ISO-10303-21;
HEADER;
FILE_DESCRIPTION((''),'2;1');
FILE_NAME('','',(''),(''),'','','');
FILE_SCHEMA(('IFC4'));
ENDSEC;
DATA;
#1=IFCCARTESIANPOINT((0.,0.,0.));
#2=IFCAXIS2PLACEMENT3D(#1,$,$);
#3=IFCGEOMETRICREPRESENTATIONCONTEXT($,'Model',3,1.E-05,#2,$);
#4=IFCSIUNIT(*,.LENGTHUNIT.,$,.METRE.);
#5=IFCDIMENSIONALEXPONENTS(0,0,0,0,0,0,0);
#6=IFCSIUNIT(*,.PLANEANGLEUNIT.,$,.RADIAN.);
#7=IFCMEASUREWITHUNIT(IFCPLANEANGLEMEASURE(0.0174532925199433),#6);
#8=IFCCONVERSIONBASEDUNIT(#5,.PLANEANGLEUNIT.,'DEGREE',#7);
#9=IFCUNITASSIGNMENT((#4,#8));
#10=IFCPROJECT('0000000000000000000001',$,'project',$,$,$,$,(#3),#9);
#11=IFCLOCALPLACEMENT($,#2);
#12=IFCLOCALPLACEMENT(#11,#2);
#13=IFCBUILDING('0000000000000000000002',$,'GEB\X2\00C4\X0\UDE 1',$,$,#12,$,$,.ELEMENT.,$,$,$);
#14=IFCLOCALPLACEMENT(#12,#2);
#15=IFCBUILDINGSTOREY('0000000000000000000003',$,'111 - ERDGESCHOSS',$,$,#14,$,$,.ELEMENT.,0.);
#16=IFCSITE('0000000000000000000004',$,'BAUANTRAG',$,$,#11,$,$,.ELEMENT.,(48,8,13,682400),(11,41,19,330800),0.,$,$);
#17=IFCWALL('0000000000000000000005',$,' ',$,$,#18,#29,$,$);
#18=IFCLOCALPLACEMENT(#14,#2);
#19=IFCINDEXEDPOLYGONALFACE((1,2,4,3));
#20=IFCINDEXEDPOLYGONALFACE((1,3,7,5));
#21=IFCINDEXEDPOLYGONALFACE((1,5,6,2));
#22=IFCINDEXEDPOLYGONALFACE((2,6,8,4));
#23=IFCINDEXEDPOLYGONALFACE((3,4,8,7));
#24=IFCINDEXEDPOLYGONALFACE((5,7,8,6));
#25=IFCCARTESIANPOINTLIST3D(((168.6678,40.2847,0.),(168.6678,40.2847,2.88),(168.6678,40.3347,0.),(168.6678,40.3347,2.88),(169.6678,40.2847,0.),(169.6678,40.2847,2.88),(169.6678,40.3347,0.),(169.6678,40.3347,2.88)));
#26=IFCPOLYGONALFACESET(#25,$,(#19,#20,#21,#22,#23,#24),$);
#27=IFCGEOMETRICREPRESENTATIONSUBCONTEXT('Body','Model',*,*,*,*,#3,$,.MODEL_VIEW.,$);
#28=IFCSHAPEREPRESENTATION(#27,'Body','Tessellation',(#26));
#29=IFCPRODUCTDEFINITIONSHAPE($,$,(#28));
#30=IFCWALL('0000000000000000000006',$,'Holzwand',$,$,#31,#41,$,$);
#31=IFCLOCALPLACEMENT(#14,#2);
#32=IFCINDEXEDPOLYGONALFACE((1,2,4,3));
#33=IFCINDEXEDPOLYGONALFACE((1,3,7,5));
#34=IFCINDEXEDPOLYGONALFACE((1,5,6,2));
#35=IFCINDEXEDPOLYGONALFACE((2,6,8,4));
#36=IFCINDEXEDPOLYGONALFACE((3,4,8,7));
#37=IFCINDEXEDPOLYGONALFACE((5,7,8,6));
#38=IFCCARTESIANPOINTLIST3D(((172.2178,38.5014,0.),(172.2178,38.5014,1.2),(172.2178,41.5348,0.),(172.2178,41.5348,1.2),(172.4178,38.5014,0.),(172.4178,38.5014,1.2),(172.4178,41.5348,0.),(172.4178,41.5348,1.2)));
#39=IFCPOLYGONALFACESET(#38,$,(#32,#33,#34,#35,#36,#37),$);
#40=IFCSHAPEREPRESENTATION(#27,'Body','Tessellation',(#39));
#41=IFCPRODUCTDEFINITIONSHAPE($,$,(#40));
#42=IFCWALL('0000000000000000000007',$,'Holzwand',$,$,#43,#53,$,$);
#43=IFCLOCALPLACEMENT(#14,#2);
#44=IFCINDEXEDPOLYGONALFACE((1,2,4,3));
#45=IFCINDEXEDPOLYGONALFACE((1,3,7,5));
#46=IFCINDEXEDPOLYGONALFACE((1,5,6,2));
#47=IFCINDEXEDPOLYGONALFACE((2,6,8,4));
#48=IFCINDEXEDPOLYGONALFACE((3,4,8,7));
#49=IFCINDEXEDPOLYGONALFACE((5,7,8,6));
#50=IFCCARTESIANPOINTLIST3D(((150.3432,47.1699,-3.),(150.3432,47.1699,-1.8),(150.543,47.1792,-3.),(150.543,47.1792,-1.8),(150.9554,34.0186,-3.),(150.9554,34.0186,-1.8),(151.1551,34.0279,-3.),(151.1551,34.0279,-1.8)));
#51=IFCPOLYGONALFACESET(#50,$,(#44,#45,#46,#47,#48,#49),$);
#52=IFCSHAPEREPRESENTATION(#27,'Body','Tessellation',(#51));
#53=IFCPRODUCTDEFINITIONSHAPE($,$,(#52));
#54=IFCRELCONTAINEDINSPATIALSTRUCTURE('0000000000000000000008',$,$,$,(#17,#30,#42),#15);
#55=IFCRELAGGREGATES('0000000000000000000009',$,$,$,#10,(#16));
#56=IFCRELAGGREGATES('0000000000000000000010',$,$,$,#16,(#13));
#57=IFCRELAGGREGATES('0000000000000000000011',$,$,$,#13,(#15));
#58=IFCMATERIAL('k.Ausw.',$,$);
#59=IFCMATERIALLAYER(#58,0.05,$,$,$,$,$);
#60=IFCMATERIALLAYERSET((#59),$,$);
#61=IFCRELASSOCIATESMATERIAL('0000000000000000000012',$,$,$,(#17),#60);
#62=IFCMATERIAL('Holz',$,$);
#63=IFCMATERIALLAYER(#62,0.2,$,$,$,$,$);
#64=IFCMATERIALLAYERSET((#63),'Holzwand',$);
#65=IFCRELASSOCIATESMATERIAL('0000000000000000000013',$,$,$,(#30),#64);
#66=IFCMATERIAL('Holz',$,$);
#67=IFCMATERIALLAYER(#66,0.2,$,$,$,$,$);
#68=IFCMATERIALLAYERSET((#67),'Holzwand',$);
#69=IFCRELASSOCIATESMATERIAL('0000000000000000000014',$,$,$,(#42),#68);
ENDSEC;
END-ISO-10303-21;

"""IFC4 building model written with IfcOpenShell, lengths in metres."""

from ifc_helpers import new_model, entity, si_unit, converted_unit, frame, frame_2d, origin, origin_with_axes, place, context, subcontext, project, spatial, rectangle, extrude, material, layer, layer_set, layer_usage, element, save


model = new_model("IFC4")

# Units and contexts
model_context = context("Model", 3, precision=1e-05, world=origin())
body_context = subcontext(model_context, "Body", "Model", "MODEL_VIEW")
ifc_project = project(units=[si_unit("LENGTHUNIT", "METRE"), converted_unit("PLANEANGLEUNIT", "DEGREE", entity("IfcPlaneAngleMeasure", 0.0174532925199433), si_unit("PLANEANGLEUNIT", "RADIAN"), dimensions=[0, 0, 0, 0, 0, 0, 0])], contexts=[model_context])

# Site, building, storey
site_placement = place(None, origin())
site = spatial("IfcSite", under=ifc_project, at=site_placement, Name="BAUANTRAG", CompositionType="ELEMENT", RefLatitude=(48, 8, 13, 682400), RefLongitude=(11, 41, 19, 330800), RefElevation=0.0)
building_placement = place(site_placement, origin())
building = spatial("IfcBuilding", under=site, at=building_placement, Name="GEBÄUDE 1", CompositionType="ELEMENT")
storey_placement = place(building_placement, origin())
storey = spatial("IfcBuildingStorey", under=building, at=storey_placement, Name="111 - ERDGESCHOSS", CompositionType="ELEMENT", Elevation=0.0)

# Walls
ifc_material_1 = material(Name="k.Ausw.")
ifc_layer_1 = layer(ifc_material_1, 0.05)
ifc_layer_set_1 = layer_set([ifc_layer_1])
ifc_layer_usage_1 = layer_usage(ifc_layer_set_1, "AXIS2", "POSITIVE", 0.0)
wall_1_placement = place(storey_placement, frame((168.6678, 40.2847, 0.0)))
element("IfcWall", 1, at=wall_1_placement, inside=storey, material=ifc_layer_usage_1, Name=" ", context=body_context, shape_type="SweptSolid", body=[
    extrude(rectangle(XDim=1.0, YDim=0.05, at=frame_2d((0.5, 0.025), x_axis=(1.0, 0.0))), origin_with_axes(), (0.0, 0.0, 1.0), 2.88),
])
ifc_material_2 = material(Name="Holz")
ifc_layer_2 = layer(ifc_material_2, 0.2)
ifc_layer_set_2 = layer_set([ifc_layer_2], Name="Holzwand")
ifc_layer_usage_2 = layer_usage(ifc_layer_set_2, "AXIS2", "POSITIVE", 0.0)
wall_2_placement = place(storey_placement, frame((172.4178, 38.5014, 0.0), z_axis=(0.0, 0.0, 1.0), x_axis=(0.0, 1.0, 0.0)))
element("IfcWall", 2, at=wall_2_placement, inside=storey, material=ifc_layer_usage_2, Name="Holzwand", context=body_context, shape_type="SweptSolid", body=[
    extrude(rectangle(XDim=3.0334, YDim=0.2, at=frame_2d((1.5167, 0.1), x_axis=(1.0, 0.0))), origin_with_axes(), (0.0, 0.0, 1.0), 1.2),
])
ifc_material_3 = material(Name="Holz")
ifc_layer_3 = layer(ifc_material_3, 0.2)
ifc_layer_set_3 = layer_set([ifc_layer_3], Name="Holzwand")
ifc_layer_usage_3 = layer_usage(ifc_layer_set_3, "AXIS2", "POSITIVE", 0.0)
wall_3_placement = place(storey_placement, frame((150.3432, 47.1699, -3.0), z_axis=(0.0, 0.0, 1.0), x_axis=(0.046495, -0.998919, 0.0)))
element("IfcWall", 3, at=wall_3_placement, inside=storey, material=ifc_layer_usage_3, Name="Holzwand", context=body_context, shape_type="SweptSolid", body=[
    extrude(rectangle(XDim=13.1655, YDim=0.2, at=frame_2d((6.5828, 0.1), x_axis=(1.0, 0.0))), origin_with_axes(), (0.0, 0.0, 1.0), 1.2),
])

save(model, "model.ifc")
